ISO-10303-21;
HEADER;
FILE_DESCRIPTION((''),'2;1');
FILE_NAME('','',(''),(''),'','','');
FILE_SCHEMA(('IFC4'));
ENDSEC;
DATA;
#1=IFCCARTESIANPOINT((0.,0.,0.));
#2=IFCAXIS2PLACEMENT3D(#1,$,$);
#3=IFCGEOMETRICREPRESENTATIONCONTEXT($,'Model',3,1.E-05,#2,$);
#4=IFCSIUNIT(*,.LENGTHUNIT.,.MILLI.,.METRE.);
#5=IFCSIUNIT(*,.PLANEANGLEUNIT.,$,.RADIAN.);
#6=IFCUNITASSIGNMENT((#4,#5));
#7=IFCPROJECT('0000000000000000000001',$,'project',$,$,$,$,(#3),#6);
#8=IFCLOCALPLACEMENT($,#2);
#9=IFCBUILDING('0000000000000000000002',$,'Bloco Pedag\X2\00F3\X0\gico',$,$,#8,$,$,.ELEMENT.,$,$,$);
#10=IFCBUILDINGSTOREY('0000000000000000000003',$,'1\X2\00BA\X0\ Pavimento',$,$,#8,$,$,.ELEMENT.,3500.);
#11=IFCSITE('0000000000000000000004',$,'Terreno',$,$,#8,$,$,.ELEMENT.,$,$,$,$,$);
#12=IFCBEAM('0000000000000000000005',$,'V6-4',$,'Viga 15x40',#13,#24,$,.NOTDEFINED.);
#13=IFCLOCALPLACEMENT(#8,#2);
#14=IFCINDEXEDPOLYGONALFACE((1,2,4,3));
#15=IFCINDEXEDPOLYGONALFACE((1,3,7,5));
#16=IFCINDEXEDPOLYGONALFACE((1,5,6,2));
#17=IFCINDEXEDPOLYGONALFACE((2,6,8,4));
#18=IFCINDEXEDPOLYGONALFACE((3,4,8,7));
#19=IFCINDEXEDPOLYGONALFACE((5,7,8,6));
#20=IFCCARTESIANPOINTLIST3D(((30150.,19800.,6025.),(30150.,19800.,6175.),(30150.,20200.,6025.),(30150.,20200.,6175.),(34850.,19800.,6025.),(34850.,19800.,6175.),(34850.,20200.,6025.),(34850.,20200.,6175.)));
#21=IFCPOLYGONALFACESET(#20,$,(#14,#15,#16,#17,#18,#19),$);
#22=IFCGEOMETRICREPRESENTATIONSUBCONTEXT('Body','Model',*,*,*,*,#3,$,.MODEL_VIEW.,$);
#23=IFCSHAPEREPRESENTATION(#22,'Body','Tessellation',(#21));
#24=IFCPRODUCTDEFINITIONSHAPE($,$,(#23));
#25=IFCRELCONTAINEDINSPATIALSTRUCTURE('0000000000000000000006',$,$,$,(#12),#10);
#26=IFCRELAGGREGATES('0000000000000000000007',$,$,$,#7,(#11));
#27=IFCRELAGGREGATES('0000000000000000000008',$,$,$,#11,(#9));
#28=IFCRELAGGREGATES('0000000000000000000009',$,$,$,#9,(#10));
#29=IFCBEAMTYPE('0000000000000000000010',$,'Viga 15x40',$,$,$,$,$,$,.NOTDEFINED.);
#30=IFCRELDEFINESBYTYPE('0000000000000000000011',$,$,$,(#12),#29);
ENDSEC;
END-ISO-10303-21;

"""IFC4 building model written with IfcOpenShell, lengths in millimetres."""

from ifc_helpers import new_model, si_unit, frame, origin, origin_2d, place, context, subcontext, project, spatial, rectangle, extrude, type_object, element, save


model = new_model("IFC4")

# Units and contexts
model_context = context("Model", 3, precision=1e-05, world=origin())
body_context = subcontext(model_context, "Body", "Model", "MODEL_VIEW")
ifc_project = project(units=[si_unit("LENGTHUNIT", "METRE", prefix="MILLI"), si_unit("PLANEANGLEUNIT", "RADIAN")], contexts=[model_context])

# Site, building, storey
placement = place(None, origin())
site = spatial("IfcSite", under=ifc_project, at=placement, Name="Terreno", CompositionType="ELEMENT")
building = spatial("IfcBuilding", under=site, at=placement, Name="Bloco Pedagógico", CompositionType="ELEMENT")
storey = spatial("IfcBuildingStorey", under=building, at=placement, Name="1º Pavimento", CompositionType="ELEMENT", Elevation=3500.0)

# Beam
beam_type = type_object("IfcBeamType", Name="Viga 15x40", PredefinedType="NOTDEFINED")
for number, where, z_axis, x_axis, name in (
    (1, (30150.0, 20000.0, 6100.0), (1.0, 0.0, 0.0), (0.0, 1.0, 0.0), "V6-4"),
):
    element("IfcBeam", number, at=place(None, frame(where, z_axis=z_axis, x_axis=x_axis)), inside=storey, type_object=beam_type, Name=name, ObjectType="Viga 15x40", PredefinedType="NOTDEFINED", context=body_context, shape_type="SweptSolid", body=[
        extrude(rectangle(XDim=400.0, YDim=150.0, at=origin_2d()), None, (0.0, 0.0, 1.0), 4700.0),
    ])

save(model, "model.ifc")
